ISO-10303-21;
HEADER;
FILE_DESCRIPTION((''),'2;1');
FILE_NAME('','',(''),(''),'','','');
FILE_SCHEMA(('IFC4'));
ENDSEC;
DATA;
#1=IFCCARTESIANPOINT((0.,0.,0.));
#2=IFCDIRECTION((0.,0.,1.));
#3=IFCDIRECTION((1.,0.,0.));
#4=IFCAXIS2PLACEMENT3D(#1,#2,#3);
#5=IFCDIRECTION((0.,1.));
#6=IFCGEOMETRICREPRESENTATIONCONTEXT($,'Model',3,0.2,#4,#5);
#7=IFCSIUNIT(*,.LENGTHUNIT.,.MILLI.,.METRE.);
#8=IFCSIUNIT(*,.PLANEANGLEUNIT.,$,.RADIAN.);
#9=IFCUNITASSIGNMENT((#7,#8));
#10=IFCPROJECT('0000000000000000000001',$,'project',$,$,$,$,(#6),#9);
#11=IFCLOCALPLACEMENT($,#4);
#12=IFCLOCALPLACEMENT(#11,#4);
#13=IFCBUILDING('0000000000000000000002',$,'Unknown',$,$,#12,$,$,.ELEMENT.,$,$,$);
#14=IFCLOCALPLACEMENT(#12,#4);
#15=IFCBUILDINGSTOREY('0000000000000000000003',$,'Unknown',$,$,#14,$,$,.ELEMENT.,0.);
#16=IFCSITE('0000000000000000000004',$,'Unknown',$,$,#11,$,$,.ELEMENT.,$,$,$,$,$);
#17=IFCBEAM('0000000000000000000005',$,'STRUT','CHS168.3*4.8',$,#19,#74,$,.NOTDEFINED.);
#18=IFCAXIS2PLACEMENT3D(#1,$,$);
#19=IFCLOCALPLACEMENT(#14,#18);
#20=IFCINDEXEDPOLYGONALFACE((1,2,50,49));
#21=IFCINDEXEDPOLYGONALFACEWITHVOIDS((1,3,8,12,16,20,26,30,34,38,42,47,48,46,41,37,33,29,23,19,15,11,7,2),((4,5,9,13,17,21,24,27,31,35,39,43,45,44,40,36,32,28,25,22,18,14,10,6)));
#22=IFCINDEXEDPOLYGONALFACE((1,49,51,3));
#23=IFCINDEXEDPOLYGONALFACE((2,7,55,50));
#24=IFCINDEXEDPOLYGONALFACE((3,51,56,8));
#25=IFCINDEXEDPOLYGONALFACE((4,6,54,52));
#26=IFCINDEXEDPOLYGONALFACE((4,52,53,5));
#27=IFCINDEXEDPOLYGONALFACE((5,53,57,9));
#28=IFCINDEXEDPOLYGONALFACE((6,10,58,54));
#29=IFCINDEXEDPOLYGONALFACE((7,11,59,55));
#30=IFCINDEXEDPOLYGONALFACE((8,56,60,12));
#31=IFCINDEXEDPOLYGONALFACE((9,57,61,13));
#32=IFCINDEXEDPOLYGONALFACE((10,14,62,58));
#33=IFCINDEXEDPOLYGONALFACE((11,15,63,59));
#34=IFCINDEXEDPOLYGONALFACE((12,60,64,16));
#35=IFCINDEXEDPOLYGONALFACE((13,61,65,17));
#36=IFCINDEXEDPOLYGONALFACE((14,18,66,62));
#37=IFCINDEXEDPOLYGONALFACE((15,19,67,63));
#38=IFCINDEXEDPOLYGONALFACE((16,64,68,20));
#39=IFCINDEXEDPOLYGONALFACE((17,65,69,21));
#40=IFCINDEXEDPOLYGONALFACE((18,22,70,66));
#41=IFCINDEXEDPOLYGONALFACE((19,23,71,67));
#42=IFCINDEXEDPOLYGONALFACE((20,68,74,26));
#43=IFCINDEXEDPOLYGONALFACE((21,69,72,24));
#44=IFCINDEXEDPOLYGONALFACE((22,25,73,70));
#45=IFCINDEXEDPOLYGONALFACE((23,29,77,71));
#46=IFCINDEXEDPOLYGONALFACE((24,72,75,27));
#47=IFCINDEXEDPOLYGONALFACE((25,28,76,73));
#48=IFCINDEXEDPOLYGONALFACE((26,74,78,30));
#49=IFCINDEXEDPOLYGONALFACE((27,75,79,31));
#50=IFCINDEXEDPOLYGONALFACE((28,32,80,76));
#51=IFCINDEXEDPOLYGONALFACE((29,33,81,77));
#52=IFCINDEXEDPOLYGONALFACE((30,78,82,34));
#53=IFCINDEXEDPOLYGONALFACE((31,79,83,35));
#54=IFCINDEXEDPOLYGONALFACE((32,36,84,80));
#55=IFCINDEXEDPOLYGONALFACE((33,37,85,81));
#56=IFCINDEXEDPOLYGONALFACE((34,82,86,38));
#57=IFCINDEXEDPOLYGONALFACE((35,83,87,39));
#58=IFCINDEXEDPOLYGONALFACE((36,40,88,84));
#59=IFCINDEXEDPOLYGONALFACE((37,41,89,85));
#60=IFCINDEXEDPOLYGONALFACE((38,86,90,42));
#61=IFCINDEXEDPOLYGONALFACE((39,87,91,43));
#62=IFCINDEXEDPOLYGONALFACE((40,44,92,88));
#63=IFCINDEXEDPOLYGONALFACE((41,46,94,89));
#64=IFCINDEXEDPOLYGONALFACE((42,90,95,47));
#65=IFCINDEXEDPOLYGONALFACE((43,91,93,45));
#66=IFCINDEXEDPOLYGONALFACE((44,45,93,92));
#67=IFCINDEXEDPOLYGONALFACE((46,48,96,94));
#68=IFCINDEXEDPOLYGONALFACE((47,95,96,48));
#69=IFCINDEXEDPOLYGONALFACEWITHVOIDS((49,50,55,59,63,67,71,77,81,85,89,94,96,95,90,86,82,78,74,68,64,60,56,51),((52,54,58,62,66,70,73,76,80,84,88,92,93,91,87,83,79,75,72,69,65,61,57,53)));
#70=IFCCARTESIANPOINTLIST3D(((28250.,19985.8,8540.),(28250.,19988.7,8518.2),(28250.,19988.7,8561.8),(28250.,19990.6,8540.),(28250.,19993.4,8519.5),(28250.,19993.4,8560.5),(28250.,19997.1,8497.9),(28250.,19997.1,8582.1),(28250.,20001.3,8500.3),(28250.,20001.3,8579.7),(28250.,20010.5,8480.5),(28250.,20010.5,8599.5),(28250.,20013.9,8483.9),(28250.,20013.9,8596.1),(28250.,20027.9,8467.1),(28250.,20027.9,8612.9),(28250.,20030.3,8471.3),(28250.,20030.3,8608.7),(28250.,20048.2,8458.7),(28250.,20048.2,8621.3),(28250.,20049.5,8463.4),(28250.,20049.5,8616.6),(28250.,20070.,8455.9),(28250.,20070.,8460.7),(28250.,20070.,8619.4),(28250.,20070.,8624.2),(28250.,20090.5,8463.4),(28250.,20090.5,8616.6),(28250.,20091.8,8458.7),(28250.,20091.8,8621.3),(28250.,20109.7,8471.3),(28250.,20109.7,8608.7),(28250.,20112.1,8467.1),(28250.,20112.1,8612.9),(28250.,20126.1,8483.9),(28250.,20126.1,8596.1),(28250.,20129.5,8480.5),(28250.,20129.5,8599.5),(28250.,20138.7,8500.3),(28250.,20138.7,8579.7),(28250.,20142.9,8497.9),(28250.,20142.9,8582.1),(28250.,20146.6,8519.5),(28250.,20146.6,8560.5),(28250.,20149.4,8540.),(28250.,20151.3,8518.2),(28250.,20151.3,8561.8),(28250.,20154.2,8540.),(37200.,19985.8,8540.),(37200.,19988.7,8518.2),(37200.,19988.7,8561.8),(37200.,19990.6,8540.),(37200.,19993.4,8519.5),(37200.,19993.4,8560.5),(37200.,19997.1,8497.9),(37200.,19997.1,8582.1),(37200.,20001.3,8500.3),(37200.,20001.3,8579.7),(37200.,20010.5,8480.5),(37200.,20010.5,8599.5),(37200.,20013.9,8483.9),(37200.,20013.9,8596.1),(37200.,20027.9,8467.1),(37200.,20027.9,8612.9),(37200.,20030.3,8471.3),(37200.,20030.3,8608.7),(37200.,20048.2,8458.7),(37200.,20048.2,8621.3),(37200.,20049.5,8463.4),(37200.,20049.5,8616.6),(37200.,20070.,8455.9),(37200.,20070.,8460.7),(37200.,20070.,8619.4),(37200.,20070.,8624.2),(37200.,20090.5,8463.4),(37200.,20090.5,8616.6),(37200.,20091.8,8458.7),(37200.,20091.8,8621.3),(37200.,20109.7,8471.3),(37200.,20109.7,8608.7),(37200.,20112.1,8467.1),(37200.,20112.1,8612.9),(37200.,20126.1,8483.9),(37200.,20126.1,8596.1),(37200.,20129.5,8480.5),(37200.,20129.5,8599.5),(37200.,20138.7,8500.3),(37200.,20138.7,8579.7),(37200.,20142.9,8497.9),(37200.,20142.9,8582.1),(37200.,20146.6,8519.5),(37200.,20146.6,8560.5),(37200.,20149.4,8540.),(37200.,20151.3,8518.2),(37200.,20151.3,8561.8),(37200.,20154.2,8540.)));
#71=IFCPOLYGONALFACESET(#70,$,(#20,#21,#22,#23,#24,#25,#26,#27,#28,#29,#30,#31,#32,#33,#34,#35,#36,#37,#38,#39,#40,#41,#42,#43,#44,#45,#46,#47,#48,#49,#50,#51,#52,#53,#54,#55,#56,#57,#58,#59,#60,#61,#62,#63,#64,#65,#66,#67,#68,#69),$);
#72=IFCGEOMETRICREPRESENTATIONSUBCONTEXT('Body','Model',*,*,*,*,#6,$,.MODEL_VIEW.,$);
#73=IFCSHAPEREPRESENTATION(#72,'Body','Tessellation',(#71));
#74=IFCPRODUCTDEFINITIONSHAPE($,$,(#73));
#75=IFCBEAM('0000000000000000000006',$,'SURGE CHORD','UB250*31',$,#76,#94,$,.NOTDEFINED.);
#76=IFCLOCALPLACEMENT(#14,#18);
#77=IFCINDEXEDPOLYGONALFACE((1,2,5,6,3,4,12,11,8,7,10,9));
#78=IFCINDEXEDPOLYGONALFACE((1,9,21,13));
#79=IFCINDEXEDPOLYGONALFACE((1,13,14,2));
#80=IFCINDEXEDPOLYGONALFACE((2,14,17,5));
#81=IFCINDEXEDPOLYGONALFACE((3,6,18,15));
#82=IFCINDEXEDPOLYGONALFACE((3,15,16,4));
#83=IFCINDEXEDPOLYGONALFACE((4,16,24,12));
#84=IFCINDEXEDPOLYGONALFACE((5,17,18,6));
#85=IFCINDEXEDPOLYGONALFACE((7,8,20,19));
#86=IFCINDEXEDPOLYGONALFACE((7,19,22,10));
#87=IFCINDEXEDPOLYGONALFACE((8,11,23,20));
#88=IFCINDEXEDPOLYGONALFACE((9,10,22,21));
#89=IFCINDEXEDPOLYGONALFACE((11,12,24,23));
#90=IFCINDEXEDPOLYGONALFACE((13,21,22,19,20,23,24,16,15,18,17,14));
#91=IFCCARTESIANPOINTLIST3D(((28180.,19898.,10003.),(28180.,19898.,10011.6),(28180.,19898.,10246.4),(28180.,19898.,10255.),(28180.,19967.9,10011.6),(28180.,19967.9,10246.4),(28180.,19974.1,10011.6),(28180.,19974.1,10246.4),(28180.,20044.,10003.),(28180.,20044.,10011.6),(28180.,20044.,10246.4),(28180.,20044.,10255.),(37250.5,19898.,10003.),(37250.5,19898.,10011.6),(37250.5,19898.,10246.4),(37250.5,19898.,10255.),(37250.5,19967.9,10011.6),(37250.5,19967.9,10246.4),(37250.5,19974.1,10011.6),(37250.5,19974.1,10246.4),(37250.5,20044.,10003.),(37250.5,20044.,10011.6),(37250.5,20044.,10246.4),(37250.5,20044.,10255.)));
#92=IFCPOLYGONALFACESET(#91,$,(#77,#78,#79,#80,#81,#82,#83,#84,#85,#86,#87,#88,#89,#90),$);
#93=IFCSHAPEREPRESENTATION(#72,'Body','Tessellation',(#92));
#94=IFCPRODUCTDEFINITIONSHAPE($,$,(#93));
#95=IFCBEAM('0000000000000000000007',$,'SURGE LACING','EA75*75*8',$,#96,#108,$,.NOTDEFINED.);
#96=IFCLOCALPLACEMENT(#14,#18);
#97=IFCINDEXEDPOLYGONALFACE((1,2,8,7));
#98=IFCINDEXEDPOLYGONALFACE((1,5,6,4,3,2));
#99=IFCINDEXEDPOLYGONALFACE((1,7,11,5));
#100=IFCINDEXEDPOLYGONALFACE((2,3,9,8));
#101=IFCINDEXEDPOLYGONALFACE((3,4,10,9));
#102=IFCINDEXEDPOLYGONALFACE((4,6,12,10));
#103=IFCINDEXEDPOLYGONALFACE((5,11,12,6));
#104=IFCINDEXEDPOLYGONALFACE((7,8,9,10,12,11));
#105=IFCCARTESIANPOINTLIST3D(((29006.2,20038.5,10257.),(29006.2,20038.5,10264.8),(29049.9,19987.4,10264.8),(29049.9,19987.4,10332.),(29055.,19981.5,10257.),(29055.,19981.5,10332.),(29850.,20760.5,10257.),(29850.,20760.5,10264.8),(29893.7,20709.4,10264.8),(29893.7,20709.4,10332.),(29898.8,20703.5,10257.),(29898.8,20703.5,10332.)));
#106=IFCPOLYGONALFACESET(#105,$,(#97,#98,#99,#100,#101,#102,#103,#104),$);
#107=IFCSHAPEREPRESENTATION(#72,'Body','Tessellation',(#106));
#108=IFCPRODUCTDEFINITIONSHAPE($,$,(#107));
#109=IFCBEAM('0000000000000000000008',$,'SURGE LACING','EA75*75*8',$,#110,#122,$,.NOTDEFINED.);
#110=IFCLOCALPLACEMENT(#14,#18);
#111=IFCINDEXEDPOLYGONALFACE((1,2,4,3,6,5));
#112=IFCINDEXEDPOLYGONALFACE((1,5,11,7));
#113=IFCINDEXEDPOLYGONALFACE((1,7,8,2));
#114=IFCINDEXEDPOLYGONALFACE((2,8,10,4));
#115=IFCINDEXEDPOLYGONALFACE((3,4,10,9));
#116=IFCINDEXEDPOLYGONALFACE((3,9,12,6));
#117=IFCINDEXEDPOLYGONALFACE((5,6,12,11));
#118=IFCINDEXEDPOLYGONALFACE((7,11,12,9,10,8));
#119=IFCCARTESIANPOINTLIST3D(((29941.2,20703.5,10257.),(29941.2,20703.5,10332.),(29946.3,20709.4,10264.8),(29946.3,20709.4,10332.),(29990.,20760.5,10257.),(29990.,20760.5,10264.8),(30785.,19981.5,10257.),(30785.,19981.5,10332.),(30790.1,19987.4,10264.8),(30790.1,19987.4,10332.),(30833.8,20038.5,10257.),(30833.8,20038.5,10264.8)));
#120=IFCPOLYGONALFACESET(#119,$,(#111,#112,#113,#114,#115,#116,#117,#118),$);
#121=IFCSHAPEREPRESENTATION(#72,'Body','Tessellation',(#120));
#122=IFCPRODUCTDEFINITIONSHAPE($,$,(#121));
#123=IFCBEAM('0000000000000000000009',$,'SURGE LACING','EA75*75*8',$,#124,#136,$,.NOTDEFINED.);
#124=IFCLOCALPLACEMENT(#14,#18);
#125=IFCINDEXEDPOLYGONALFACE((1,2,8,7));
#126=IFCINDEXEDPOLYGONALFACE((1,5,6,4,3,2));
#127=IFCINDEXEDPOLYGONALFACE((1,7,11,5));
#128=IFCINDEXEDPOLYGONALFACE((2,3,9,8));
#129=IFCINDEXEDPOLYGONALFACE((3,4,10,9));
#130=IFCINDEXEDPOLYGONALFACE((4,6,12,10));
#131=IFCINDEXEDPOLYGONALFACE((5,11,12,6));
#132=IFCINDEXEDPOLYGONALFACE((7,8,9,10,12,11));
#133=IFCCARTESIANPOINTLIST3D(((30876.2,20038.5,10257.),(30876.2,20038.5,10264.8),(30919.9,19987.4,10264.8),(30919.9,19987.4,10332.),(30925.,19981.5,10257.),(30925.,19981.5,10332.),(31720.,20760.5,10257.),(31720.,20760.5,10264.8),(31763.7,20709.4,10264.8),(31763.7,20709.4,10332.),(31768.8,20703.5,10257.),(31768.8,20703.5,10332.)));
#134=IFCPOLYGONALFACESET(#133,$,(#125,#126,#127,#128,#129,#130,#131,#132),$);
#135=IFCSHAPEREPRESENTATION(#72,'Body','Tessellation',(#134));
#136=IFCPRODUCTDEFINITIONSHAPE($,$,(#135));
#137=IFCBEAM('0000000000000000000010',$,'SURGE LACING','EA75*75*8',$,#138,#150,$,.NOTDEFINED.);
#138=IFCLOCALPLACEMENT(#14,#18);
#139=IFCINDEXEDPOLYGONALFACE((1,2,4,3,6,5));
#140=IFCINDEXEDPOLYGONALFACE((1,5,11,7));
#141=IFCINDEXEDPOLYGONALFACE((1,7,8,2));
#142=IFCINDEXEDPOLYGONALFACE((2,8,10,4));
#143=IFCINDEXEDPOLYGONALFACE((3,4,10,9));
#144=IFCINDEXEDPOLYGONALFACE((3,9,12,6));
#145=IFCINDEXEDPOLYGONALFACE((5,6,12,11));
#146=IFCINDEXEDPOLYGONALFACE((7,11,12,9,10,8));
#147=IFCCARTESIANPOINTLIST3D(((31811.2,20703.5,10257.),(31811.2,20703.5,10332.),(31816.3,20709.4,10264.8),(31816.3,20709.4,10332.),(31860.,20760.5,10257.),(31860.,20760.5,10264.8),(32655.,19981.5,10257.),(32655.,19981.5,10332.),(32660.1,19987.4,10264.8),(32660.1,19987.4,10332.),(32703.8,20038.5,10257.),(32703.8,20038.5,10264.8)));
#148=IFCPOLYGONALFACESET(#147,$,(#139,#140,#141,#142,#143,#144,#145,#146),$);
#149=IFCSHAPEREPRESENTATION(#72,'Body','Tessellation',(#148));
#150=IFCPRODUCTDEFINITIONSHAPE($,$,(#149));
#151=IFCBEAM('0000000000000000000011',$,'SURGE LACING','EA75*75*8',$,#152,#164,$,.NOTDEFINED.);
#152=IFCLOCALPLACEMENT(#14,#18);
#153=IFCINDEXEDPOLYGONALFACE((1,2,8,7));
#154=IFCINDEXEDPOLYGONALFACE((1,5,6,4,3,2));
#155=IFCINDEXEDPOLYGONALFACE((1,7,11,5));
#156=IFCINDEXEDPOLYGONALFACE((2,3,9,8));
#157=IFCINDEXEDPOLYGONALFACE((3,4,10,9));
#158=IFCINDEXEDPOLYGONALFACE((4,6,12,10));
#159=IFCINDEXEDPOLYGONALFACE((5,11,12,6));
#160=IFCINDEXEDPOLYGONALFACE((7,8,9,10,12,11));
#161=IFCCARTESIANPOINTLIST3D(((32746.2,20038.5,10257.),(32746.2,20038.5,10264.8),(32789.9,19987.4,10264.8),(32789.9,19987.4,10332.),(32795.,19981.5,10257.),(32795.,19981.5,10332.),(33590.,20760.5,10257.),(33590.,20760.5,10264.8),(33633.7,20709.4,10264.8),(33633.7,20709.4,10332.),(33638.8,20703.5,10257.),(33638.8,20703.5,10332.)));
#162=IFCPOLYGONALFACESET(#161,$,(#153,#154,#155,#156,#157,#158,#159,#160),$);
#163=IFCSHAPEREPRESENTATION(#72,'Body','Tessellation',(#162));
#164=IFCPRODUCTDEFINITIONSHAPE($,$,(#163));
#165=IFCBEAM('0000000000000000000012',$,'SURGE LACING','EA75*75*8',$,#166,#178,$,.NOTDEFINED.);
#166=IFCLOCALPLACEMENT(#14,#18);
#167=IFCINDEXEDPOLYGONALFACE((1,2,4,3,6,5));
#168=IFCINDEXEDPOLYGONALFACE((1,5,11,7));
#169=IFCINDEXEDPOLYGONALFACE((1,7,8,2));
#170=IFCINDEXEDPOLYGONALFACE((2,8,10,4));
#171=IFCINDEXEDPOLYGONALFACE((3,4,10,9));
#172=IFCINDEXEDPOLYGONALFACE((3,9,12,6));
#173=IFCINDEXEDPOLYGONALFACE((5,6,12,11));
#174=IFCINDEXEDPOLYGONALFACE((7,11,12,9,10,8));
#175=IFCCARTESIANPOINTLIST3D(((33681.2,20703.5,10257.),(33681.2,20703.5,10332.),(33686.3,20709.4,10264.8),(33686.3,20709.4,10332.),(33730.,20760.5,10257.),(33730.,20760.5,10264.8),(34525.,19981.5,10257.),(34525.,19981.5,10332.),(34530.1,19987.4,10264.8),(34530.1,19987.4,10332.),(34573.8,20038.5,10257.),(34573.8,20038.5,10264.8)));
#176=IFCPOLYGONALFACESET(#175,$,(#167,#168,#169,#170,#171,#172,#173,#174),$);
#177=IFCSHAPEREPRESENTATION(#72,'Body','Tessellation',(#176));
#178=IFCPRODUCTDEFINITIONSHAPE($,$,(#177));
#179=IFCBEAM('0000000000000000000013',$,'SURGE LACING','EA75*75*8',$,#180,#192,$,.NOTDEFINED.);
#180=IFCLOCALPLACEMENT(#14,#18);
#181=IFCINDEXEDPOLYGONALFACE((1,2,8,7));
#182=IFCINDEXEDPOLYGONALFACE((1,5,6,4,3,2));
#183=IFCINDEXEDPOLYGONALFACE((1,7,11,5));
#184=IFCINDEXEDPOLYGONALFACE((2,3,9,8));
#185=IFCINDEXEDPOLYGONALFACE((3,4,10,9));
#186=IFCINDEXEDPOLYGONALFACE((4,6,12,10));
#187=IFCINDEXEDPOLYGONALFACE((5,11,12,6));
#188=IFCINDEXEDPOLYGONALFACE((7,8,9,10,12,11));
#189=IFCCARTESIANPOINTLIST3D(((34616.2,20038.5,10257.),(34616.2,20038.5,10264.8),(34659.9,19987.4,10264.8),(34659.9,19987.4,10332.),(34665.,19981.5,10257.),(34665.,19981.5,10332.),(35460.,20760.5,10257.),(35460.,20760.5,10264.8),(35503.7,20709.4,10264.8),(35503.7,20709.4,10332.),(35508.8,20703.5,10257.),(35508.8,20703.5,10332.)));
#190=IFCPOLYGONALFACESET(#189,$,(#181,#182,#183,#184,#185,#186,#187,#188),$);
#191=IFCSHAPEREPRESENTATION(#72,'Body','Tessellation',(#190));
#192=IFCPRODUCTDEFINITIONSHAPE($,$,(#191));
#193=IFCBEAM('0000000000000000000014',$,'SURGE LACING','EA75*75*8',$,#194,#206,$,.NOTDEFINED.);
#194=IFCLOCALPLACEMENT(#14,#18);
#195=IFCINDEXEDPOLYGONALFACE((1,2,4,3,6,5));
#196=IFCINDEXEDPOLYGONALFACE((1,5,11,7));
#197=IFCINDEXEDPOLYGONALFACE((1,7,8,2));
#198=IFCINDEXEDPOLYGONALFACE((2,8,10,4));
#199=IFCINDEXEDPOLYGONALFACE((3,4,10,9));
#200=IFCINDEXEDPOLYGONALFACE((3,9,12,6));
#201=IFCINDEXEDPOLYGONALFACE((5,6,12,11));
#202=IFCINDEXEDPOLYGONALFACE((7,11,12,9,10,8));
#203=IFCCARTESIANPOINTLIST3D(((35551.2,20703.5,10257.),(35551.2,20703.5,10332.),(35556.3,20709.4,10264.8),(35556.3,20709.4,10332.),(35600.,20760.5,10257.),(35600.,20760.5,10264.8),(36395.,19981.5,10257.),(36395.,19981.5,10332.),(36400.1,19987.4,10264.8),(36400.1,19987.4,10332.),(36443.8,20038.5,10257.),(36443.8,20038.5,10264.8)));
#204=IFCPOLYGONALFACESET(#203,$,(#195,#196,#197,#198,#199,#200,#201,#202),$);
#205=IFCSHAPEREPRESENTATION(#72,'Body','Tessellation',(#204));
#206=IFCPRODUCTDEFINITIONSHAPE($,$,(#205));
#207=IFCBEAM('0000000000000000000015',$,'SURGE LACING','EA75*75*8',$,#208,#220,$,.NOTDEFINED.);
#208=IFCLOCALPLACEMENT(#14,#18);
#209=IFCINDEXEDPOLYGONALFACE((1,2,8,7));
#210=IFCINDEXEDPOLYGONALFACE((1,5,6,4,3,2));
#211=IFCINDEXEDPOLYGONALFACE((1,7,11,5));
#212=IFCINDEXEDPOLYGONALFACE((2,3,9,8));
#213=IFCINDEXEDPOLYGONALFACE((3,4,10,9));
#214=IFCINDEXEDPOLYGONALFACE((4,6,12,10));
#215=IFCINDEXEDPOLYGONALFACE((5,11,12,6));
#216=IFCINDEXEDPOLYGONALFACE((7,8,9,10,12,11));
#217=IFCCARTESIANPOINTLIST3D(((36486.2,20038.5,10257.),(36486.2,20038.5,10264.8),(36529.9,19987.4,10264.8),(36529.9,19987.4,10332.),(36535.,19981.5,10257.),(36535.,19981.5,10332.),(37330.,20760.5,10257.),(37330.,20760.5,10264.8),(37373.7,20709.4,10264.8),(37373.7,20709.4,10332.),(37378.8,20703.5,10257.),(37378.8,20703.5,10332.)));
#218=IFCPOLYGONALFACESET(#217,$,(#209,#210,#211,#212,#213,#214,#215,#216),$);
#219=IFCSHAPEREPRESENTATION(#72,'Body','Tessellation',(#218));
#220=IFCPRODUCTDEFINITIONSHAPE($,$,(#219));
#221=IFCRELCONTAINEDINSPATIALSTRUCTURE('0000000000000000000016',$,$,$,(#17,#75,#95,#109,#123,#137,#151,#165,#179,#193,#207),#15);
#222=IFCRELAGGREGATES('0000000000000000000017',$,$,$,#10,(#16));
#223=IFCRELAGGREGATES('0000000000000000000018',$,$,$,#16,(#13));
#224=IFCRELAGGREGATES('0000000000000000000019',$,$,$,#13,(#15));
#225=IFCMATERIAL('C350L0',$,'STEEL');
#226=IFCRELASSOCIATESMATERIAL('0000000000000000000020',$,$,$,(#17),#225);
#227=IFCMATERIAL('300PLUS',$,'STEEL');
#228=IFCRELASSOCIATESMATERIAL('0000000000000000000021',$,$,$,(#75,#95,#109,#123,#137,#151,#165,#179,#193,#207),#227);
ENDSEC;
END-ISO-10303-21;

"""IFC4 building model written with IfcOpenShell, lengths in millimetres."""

from ifc_helpers import new_model, si_unit, direction, frame, origin_with_axes, place, context, subcontext, project, spatial, line, indexed_curve, outline, extrude, material, element, save


model = new_model("IFC4")

# Units and contexts
model_context = context("Model", 3, precision=0.2, world=origin_with_axes(), true_north=direction((0.0, 1.0)))
body_context = subcontext(model_context, "Body", "Model", "MODEL_VIEW")
ifc_project = project(units=[si_unit("LENGTHUNIT", "METRE", prefix="MILLI"), si_unit("PLANEANGLEUNIT", "RADIAN")], contexts=[model_context])

# Site, building, storey
site_placement = place(None, origin_with_axes())
site = spatial("IfcSite", under=ifc_project, at=site_placement, Name="Unknown", CompositionType="ELEMENT")
building_placement = place(site_placement, origin_with_axes())
building = spatial("IfcBuilding", under=site, at=building_placement, Name="Unknown", CompositionType="ELEMENT")
storey_placement = place(building_placement, origin_with_axes())
storey = spatial("IfcBuildingStorey", under=building, at=storey_placement, Name="Unknown", CompositionType="ELEMENT", Elevation=0.0)

# Shared definitions
ifc_material_1 = material(Name="C350L0", Category="STEEL")

# Shared definitions
ifc_material_2 = material(Name="300PLUS", Category="STEEL")

# Beams
beam_1_placement = place(storey_placement, frame((28250.0, 20070.0, 8540.0), z_axis=(0.0, 0.0, 1.0), x_axis=(1.0, 0.0, 0.0)))
element("IfcBeam", 1, at=beam_1_placement, inside=storey, material=ifc_material_1, Name="STRUT", Description="CHS168.3*4.8", PredefinedType="NOTDEFINED", context=body_context, shape_type="SolidModel", body=[
    extrude(outline(indexed_curve([(84.2, 0.0), (81.3, 21.8), (72.9, 42.1), (59.5, 59.5), (42.1, 72.9), (21.8, 81.3), (0.0, 84.2), (-21.8, 81.3), (-42.1, 72.9), (-59.5, 59.5), (-72.9, 42.1), (-81.3, 21.8), (-84.2, 0.0), (-81.3, -21.8), (-72.9, -42.1), (-59.5, -59.5), (-42.1, -72.9), (-21.8, -81.3), (0.0, -84.2), (21.8, -81.3), (42.1, -72.9), (59.5, -59.5), (72.9, -42.1), (81.3, -21.8)], segments=[line(1, 2, 3, 4, 5, 6, 7, 8, 9, 10, 11, 12, 13, 14, 15, 16, 17, 18, 19, 20, 21, 22, 23, 24, 1)]), holes=[indexed_curve([(79.3, 0.0), (76.6, -20.5), (68.7, -39.7), (56.1, -56.1), (39.7, -68.7), (20.5, -76.6), (0.0, -79.3), (-20.5, -76.6), (-39.7, -68.7), (-56.1, -56.1), (-68.7, -39.7), (-76.6, -20.5), (-79.3, 0.0), (-76.6, 20.5), (-68.7, 39.7), (-56.1, 56.1), (-39.7, 68.7), (-20.5, 76.6), (0.0, 79.3), (20.5, 76.6), (39.7, 68.7), (56.1, 56.1), (68.7, 39.7), (76.6, 20.5)], segments=[line(1, 2, 3, 4, 5, 6, 7, 8, 9, 10, 11, 12, 13, 14, 15, 16, 17, 18, 19, 20, 21, 22, 23, 24, 1)])]), frame((0.0, 0.0, 0.0), z_axis=(-1.0, 0.0, 0.0), x_axis=(0.0, 0.0, 1.0)), (0.0, 0.0, -1.0), 8950.0),
])
beam_2_placement = place(storey_placement, frame((28180.0, 19971.0, 10129.0), z_axis=(0.0, -1.0, 0.0), x_axis=(1.0, 0.0, 0.0)))
element("IfcBeam", 2, at=beam_2_placement, inside=storey, material=ifc_material_2, Name="SURGE CHORD", Description="UB250*31", PredefinedType="NOTDEFINED", context=body_context, shape_type="SolidModel", body=[
    extrude(outline(indexed_curve([(-73.0, -126.0), (73.0, -126.0), (73.0, -117.4), (3.0, -117.4), (3.0, 117.4), (73.0, 117.4), (73.0, 126.0), (-73.0, 126.0), (-73.0, 117.4), (-3.0, 117.4), (-3.0, -117.4), (-73.0, -117.4)], segments=[line(1, 2, 3, 4, 5, 6, 7, 8, 9, 10, 11, 12, 1)])), frame((0.0, 0.0, 0.0), z_axis=(-1.0, 0.0, 0.0), x_axis=(0.0, 0.0, 1.0)), (0.0, 0.0, -1.0), 9070.5),
])
for number, where, z_axis, x_axis, name in (
    (3, (29030.6, 20010.0, 10294.5), (0.0, 0.0, 1.0), (0.759816, 0.650139, 0.0), "SURGE LACING"),
    (4, (29965.6, 20732.0, 10294.5), (0.0, 0.0, 1.0), (0.759816, -0.650139, 0.0), "SURGE LACING"),
    (5, (30900.6, 20010.0, 10294.5), (0.0, 0.0, 1.0), (0.759816, 0.650139, 0.0), "SURGE LACING"),
    (6, (31835.6, 20732.0, 10294.5), (0.0, 0.0, 1.0), (0.759816, -0.650139, 0.0), "SURGE LACING"),
    (7, (32770.6, 20010.0, 10294.5), (0.0, 0.0, 1.0), (0.759816, 0.650139, 0.0), "SURGE LACING"),
    (8, (33705.6, 20732.0, 10294.5), (0.0, 0.0, 1.0), (0.759816, -0.650139, 0.0), "SURGE LACING"),
    (9, (34640.6, 20010.0, 10294.5), (0.0, 0.0, 1.0), (0.759816, 0.650139, 0.0), "SURGE LACING"),
    (10, (35575.6, 20732.0, 10294.5), (0.0, 0.0, 1.0), (0.759816, -0.650139, 0.0), "SURGE LACING"),
    (11, (36510.6, 20010.0, 10294.5), (0.0, 0.0, 1.0), (0.759816, 0.650139, 0.0), "SURGE LACING"),
):
    element("IfcBeam", number, at=place(storey_placement, frame(where, z_axis=z_axis, x_axis=x_axis)), inside=storey, material=ifc_material_2, Name=name, Description="EA75*75*8", PredefinedType="NOTDEFINED", context=body_context, shape_type="SolidModel", body=[
        extrude(outline(indexed_curve([(-37.5, -37.5), (37.5, -37.5), (37.5, -29.7), (-29.7, -29.7), (-29.7, 37.5), (-37.5, 37.5)], segments=[line(1, 2, 3, 4, 5, 6, 1)])), frame((0.0, 0.0, 0.0), z_axis=(-1.0, 0.0, 0.0), x_axis=(0.0, 0.0, 1.0)), (0.0, 0.0, -1.0), 1110.5),
    ])

save(model, "model.ifc")
